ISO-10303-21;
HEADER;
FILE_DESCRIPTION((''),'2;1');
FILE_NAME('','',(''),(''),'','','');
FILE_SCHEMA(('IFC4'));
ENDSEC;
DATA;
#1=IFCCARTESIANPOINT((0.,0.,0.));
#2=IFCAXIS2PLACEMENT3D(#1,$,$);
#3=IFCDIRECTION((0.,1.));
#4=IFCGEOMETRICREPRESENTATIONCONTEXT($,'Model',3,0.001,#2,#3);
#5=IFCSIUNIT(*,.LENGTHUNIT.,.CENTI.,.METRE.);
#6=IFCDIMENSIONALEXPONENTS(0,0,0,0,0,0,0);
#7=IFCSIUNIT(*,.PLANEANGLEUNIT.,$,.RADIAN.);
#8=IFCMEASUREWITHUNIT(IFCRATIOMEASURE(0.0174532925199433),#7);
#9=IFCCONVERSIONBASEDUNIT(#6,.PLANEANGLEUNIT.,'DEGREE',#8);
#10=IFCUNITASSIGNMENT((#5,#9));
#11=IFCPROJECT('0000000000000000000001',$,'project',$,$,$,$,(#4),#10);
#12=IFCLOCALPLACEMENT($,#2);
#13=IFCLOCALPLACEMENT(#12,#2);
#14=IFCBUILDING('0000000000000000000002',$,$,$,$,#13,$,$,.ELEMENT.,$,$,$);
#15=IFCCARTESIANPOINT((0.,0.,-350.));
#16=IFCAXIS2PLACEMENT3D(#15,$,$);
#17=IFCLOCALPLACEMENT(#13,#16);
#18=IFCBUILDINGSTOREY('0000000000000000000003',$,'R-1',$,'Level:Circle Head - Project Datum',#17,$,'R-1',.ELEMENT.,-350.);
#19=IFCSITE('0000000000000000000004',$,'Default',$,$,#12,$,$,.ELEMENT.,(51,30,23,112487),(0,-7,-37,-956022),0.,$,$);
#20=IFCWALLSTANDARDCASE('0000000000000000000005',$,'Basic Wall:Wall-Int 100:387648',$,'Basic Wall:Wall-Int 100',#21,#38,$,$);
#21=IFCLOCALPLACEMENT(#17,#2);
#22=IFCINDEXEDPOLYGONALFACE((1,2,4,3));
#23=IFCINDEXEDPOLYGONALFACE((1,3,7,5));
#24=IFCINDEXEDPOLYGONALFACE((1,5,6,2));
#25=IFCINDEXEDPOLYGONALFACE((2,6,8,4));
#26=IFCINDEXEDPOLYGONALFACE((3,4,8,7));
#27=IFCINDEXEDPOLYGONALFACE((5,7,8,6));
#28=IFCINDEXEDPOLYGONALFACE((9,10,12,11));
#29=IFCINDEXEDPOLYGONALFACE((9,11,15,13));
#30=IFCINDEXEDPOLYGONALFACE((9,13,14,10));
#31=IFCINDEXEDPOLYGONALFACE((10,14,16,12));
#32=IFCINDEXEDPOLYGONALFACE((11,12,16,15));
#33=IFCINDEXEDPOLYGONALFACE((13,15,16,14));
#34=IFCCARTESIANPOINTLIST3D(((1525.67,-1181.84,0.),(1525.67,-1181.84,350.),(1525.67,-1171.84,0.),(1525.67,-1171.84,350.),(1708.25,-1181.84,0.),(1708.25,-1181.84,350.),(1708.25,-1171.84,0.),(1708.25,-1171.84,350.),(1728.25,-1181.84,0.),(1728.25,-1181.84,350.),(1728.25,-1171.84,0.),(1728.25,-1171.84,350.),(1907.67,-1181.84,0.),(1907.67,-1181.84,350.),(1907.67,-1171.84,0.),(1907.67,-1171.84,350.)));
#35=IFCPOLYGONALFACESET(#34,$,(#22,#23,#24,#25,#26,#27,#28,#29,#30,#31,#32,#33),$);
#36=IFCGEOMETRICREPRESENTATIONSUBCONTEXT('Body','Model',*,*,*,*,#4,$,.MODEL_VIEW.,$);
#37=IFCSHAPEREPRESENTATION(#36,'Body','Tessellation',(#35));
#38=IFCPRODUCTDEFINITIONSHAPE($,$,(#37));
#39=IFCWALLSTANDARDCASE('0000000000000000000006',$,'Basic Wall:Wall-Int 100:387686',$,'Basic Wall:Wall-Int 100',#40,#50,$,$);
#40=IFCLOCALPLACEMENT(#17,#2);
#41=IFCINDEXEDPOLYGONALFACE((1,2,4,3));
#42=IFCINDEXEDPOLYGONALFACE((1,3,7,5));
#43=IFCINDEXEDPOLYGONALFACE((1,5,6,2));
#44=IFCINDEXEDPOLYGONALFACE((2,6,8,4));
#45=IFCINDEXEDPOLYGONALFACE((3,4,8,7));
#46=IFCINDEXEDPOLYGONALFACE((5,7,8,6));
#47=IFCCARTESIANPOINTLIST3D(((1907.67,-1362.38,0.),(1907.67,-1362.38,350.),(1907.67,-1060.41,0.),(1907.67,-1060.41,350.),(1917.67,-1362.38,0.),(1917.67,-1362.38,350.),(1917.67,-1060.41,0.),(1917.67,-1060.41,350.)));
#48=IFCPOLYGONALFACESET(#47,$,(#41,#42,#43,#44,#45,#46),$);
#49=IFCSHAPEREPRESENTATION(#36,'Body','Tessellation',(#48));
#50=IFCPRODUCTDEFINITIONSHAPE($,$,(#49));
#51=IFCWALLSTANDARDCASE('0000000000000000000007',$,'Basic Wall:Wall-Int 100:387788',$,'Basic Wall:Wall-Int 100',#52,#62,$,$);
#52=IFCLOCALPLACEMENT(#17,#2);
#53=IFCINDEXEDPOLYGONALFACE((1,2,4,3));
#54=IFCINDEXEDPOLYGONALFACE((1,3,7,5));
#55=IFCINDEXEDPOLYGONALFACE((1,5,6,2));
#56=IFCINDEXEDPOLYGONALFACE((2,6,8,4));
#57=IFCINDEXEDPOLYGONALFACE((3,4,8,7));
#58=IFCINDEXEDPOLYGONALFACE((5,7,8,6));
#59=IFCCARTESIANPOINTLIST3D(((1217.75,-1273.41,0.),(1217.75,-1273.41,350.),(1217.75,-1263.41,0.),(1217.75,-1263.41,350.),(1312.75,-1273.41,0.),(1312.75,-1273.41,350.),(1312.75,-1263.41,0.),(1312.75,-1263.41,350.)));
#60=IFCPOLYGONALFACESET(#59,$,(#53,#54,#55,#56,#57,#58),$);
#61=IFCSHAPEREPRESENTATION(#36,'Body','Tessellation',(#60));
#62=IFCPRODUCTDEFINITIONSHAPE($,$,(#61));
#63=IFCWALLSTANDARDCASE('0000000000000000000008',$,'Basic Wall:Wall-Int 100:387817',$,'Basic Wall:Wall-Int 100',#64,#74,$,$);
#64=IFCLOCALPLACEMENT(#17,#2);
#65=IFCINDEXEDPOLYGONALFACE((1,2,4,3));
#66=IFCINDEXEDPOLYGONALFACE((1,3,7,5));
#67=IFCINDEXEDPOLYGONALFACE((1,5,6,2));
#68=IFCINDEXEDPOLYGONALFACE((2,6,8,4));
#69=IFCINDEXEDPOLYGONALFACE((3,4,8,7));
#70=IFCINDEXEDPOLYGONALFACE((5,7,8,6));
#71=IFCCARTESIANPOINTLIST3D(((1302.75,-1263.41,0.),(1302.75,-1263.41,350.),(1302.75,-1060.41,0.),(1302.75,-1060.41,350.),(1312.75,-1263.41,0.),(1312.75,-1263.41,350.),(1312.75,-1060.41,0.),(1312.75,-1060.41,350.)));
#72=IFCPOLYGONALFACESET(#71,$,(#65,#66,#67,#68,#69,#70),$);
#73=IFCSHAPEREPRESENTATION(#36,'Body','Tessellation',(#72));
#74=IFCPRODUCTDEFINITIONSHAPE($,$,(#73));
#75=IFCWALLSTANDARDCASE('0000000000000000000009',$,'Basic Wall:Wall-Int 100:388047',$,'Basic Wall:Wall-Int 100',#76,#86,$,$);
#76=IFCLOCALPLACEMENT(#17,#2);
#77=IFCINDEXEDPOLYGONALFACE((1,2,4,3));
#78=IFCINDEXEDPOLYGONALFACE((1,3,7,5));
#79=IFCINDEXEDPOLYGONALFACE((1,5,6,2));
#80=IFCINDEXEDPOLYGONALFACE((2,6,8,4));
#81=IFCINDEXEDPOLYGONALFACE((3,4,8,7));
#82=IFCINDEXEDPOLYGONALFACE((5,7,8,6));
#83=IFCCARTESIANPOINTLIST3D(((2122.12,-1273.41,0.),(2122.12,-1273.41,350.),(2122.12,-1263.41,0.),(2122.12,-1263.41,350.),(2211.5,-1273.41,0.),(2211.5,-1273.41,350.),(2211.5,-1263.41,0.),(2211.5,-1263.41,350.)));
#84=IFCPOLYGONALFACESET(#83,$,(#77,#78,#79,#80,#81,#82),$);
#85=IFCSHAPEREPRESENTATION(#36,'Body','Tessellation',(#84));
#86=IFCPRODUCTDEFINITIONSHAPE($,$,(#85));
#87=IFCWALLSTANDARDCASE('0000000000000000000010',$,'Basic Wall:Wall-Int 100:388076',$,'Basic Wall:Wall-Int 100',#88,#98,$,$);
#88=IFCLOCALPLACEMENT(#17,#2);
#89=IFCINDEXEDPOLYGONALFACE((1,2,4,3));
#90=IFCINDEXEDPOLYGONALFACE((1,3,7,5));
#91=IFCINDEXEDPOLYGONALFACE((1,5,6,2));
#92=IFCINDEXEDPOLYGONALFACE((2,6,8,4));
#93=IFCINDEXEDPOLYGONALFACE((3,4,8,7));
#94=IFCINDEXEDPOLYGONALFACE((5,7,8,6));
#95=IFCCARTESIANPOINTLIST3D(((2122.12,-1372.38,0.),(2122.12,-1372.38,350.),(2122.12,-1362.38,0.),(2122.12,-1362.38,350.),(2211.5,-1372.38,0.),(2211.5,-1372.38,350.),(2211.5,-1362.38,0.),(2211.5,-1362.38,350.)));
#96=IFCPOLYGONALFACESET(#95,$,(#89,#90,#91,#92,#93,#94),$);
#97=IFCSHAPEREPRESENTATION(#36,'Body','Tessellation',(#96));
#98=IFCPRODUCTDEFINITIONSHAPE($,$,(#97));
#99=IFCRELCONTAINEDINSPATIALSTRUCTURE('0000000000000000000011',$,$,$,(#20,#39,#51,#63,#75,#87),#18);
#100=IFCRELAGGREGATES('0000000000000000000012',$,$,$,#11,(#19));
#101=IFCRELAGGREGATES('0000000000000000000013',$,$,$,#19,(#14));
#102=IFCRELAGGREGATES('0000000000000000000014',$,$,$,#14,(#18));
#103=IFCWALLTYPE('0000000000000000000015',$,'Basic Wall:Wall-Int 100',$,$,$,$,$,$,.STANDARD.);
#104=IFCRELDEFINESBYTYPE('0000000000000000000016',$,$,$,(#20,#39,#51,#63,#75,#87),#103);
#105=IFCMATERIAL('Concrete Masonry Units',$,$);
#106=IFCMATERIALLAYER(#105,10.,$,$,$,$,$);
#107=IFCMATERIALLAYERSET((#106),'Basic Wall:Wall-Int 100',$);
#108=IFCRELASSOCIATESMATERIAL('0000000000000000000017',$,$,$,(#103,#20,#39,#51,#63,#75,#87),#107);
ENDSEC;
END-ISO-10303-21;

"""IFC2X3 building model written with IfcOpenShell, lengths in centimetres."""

from ifc_helpers import new_model, entity, si_unit, converted_unit, direction, frame, frame_2d, origin, place, context, subcontext, project, spatial, rectangle, extrude, material, layer, layer_set, layer_usage, type_object, element, save


model = new_model("IFC2X3")

# Units and contexts
model_context = context("Model", 3, precision=0.001, world=origin(), true_north=direction((0.0, 1.0)))
body_context = subcontext(model_context, "Body", "Model", "MODEL_VIEW")
ifc_project = project(units=[si_unit("LENGTHUNIT", "METRE", prefix="CENTI"), converted_unit("PLANEANGLEUNIT", "DEGREE", entity("IfcRatioMeasure", 0.0174532925199433), si_unit("PLANEANGLEUNIT", "RADIAN"), dimensions=[0, 0, 0, 0, 0, 0, 0])], contexts=[model_context])

# Site, building, storey
site_placement = place(None, origin())
site = spatial("IfcSite", under=ifc_project, at=site_placement, Name="Default", CompositionType="ELEMENT", RefLatitude=(51, 30, 23, 112487), RefLongitude=(0, -7, -37, -956022), RefElevation=0.0)
building_placement = place(site_placement, origin())
building = spatial("IfcBuilding", under=site, at=building_placement, CompositionType="ELEMENT")
storey_placement = place(building_placement, frame((0.0, 0.0, -350.0)))
storey = spatial("IfcBuildingStorey", under=building, at=storey_placement, Name="R-1", ObjectType="Level:Circle Head - Project Datum", LongName="R-1", CompositionType="ELEMENT", Elevation=-350.0)

# Shared definitions
ifc_material_1 = material(Name="Concrete Masonry Units")
ifc_layer_1 = layer(ifc_material_1, 10.0)
ifc_layer_set_1 = layer_set([ifc_layer_1], Name="Basic Wall:Wall-Int 100")
wall_type_1 = type_object("IfcWallType", Name="Basic Wall:Wall-Int 100", PredefinedType="STANDARD", material=ifc_layer_set_1)

# Wall, opening
ifc_layer_usage_1 = layer_usage(ifc_layer_set_1, "AXIS2", "NEGATIVE", 5.0)
wall_1_placement = place(storey_placement, frame((1525.67, -1176.84, 0.0)))
wall_1 = element("IfcWallStandardCase", 1, at=wall_1_placement, inside=storey, type_object=wall_type_1, material=ifc_layer_usage_1, Name="Basic Wall:Wall-Int 100:387648", ObjectType="Basic Wall:Wall-Int 100", context=body_context, shape_type="SweptSolid", body=[
    extrude(rectangle(XDim=382.0, YDim=10.0, at=frame_2d((191.0, 0.0), x_axis=(-1.0, 0.0))), origin(), (0.0, 0.0, 1.0), 350.0),
])
opening_placement = place(storey_placement, frame((1525.67, -1176.84, 0.0)))
element("IfcOpeningElement", 2, at=opening_placement, cuts=wall_1, ObjectType="Opening", context=body_context, shape_type="SweptSolid", body=[
    extrude(rectangle(XDim=350.0, YDim=10.0, at=frame_2d((0.0, 0.0), x_axis=(1.0, 0.0))), frame((182.57, 0.0, 175.0), z_axis=(1.0, 0.0, 0.0), x_axis=(0.0, 0.0, -1.0)), (0.0, 0.0, 1.0), 20.0),
])

# Walls
ifc_layer_usage_2 = layer_usage(ifc_layer_set_1, "AXIS2", "NEGATIVE", 5.0)
wall_2_placement = place(storey_placement, frame((1912.67, -1362.38, 0.0), z_axis=(0.0, 0.0, 1.0), x_axis=(0.0, 1.0, 0.0)))
element("IfcWallStandardCase", 3, at=wall_2_placement, inside=storey, type_object=wall_type_1, material=ifc_layer_usage_2, Name="Basic Wall:Wall-Int 100:387686", ObjectType="Basic Wall:Wall-Int 100", context=body_context, shape_type="SweptSolid", body=[
    extrude(rectangle(XDim=301.97, YDim=10.0, at=frame_2d((150.98, 0.0), x_axis=(-1.0, 0.0))), origin(), (0.0, 0.0, 1.0), 350.0),
])
ifc_layer_usage_3 = layer_usage(ifc_layer_set_1, "AXIS2", "NEGATIVE", 5.0)
wall_3_placement = place(storey_placement, frame((1217.75, -1268.41, 0.0)))
element("IfcWallStandardCase", 4, at=wall_3_placement, inside=storey, type_object=wall_type_1, material=ifc_layer_usage_3, Name="Basic Wall:Wall-Int 100:387788", ObjectType="Basic Wall:Wall-Int 100", context=body_context, shape_type="SweptSolid", body=[
    extrude(rectangle(XDim=95.0, YDim=10.0, at=frame_2d((47.5, 0.0), x_axis=(-1.0, 0.0))), origin(), (0.0, 0.0, 1.0), 350.0),
])
ifc_layer_usage_4 = layer_usage(ifc_layer_set_1, "AXIS2", "NEGATIVE", 5.0)
wall_4_placement = place(storey_placement, frame((1307.75, -1060.41, 0.0), z_axis=(0.0, 0.0, 1.0), x_axis=(0.0, -1.0, 0.0)))
element("IfcWallStandardCase", 5, at=wall_4_placement, inside=storey, type_object=wall_type_1, material=ifc_layer_usage_4, Name="Basic Wall:Wall-Int 100:387817", ObjectType="Basic Wall:Wall-Int 100", context=body_context, shape_type="SweptSolid", body=[
    extrude(rectangle(XDim=203.0, YDim=10.0, at=frame_2d((101.5, 0.0), x_axis=(-1.0, 0.0))), origin(), (0.0, 0.0, 1.0), 350.0),
])
ifc_layer_usage_5 = layer_usage(ifc_layer_set_1, "AXIS2", "NEGATIVE", 5.0)
wall_5_placement = place(storey_placement, frame((2211.5, -1268.41, 0.0), z_axis=(0.0, 0.0, 1.0), x_axis=(-1.0, 0.0, 0.0)))
element("IfcWallStandardCase", 6, at=wall_5_placement, inside=storey, type_object=wall_type_1, material=ifc_layer_usage_5, Name="Basic Wall:Wall-Int 100:388047", ObjectType="Basic Wall:Wall-Int 100", context=body_context, shape_type="SweptSolid", body=[
    extrude(rectangle(XDim=89.38, YDim=10.0, at=frame_2d((44.69, 0.0), x_axis=(-1.0, 0.0))), origin(), (0.0, 0.0, 1.0), 350.0),
])
ifc_layer_usage_6 = layer_usage(ifc_layer_set_1, "AXIS2", "NEGATIVE", 5.0)
wall_6_placement = place(storey_placement, frame((2211.5, -1367.38, 0.0), z_axis=(0.0, 0.0, 1.0), x_axis=(-1.0, 0.0, 0.0)))
element("IfcWallStandardCase", 7, at=wall_6_placement, inside=storey, type_object=wall_type_1, material=ifc_layer_usage_6, Name="Basic Wall:Wall-Int 100:388076", ObjectType="Basic Wall:Wall-Int 100", context=body_context, shape_type="SweptSolid", body=[
    extrude(rectangle(XDim=89.38, YDim=10.0, at=frame_2d((44.69, 0.0), x_axis=(-1.0, 0.0))), origin(), (0.0, 0.0, 1.0), 350.0),
])

save(model, "model.ifc")
